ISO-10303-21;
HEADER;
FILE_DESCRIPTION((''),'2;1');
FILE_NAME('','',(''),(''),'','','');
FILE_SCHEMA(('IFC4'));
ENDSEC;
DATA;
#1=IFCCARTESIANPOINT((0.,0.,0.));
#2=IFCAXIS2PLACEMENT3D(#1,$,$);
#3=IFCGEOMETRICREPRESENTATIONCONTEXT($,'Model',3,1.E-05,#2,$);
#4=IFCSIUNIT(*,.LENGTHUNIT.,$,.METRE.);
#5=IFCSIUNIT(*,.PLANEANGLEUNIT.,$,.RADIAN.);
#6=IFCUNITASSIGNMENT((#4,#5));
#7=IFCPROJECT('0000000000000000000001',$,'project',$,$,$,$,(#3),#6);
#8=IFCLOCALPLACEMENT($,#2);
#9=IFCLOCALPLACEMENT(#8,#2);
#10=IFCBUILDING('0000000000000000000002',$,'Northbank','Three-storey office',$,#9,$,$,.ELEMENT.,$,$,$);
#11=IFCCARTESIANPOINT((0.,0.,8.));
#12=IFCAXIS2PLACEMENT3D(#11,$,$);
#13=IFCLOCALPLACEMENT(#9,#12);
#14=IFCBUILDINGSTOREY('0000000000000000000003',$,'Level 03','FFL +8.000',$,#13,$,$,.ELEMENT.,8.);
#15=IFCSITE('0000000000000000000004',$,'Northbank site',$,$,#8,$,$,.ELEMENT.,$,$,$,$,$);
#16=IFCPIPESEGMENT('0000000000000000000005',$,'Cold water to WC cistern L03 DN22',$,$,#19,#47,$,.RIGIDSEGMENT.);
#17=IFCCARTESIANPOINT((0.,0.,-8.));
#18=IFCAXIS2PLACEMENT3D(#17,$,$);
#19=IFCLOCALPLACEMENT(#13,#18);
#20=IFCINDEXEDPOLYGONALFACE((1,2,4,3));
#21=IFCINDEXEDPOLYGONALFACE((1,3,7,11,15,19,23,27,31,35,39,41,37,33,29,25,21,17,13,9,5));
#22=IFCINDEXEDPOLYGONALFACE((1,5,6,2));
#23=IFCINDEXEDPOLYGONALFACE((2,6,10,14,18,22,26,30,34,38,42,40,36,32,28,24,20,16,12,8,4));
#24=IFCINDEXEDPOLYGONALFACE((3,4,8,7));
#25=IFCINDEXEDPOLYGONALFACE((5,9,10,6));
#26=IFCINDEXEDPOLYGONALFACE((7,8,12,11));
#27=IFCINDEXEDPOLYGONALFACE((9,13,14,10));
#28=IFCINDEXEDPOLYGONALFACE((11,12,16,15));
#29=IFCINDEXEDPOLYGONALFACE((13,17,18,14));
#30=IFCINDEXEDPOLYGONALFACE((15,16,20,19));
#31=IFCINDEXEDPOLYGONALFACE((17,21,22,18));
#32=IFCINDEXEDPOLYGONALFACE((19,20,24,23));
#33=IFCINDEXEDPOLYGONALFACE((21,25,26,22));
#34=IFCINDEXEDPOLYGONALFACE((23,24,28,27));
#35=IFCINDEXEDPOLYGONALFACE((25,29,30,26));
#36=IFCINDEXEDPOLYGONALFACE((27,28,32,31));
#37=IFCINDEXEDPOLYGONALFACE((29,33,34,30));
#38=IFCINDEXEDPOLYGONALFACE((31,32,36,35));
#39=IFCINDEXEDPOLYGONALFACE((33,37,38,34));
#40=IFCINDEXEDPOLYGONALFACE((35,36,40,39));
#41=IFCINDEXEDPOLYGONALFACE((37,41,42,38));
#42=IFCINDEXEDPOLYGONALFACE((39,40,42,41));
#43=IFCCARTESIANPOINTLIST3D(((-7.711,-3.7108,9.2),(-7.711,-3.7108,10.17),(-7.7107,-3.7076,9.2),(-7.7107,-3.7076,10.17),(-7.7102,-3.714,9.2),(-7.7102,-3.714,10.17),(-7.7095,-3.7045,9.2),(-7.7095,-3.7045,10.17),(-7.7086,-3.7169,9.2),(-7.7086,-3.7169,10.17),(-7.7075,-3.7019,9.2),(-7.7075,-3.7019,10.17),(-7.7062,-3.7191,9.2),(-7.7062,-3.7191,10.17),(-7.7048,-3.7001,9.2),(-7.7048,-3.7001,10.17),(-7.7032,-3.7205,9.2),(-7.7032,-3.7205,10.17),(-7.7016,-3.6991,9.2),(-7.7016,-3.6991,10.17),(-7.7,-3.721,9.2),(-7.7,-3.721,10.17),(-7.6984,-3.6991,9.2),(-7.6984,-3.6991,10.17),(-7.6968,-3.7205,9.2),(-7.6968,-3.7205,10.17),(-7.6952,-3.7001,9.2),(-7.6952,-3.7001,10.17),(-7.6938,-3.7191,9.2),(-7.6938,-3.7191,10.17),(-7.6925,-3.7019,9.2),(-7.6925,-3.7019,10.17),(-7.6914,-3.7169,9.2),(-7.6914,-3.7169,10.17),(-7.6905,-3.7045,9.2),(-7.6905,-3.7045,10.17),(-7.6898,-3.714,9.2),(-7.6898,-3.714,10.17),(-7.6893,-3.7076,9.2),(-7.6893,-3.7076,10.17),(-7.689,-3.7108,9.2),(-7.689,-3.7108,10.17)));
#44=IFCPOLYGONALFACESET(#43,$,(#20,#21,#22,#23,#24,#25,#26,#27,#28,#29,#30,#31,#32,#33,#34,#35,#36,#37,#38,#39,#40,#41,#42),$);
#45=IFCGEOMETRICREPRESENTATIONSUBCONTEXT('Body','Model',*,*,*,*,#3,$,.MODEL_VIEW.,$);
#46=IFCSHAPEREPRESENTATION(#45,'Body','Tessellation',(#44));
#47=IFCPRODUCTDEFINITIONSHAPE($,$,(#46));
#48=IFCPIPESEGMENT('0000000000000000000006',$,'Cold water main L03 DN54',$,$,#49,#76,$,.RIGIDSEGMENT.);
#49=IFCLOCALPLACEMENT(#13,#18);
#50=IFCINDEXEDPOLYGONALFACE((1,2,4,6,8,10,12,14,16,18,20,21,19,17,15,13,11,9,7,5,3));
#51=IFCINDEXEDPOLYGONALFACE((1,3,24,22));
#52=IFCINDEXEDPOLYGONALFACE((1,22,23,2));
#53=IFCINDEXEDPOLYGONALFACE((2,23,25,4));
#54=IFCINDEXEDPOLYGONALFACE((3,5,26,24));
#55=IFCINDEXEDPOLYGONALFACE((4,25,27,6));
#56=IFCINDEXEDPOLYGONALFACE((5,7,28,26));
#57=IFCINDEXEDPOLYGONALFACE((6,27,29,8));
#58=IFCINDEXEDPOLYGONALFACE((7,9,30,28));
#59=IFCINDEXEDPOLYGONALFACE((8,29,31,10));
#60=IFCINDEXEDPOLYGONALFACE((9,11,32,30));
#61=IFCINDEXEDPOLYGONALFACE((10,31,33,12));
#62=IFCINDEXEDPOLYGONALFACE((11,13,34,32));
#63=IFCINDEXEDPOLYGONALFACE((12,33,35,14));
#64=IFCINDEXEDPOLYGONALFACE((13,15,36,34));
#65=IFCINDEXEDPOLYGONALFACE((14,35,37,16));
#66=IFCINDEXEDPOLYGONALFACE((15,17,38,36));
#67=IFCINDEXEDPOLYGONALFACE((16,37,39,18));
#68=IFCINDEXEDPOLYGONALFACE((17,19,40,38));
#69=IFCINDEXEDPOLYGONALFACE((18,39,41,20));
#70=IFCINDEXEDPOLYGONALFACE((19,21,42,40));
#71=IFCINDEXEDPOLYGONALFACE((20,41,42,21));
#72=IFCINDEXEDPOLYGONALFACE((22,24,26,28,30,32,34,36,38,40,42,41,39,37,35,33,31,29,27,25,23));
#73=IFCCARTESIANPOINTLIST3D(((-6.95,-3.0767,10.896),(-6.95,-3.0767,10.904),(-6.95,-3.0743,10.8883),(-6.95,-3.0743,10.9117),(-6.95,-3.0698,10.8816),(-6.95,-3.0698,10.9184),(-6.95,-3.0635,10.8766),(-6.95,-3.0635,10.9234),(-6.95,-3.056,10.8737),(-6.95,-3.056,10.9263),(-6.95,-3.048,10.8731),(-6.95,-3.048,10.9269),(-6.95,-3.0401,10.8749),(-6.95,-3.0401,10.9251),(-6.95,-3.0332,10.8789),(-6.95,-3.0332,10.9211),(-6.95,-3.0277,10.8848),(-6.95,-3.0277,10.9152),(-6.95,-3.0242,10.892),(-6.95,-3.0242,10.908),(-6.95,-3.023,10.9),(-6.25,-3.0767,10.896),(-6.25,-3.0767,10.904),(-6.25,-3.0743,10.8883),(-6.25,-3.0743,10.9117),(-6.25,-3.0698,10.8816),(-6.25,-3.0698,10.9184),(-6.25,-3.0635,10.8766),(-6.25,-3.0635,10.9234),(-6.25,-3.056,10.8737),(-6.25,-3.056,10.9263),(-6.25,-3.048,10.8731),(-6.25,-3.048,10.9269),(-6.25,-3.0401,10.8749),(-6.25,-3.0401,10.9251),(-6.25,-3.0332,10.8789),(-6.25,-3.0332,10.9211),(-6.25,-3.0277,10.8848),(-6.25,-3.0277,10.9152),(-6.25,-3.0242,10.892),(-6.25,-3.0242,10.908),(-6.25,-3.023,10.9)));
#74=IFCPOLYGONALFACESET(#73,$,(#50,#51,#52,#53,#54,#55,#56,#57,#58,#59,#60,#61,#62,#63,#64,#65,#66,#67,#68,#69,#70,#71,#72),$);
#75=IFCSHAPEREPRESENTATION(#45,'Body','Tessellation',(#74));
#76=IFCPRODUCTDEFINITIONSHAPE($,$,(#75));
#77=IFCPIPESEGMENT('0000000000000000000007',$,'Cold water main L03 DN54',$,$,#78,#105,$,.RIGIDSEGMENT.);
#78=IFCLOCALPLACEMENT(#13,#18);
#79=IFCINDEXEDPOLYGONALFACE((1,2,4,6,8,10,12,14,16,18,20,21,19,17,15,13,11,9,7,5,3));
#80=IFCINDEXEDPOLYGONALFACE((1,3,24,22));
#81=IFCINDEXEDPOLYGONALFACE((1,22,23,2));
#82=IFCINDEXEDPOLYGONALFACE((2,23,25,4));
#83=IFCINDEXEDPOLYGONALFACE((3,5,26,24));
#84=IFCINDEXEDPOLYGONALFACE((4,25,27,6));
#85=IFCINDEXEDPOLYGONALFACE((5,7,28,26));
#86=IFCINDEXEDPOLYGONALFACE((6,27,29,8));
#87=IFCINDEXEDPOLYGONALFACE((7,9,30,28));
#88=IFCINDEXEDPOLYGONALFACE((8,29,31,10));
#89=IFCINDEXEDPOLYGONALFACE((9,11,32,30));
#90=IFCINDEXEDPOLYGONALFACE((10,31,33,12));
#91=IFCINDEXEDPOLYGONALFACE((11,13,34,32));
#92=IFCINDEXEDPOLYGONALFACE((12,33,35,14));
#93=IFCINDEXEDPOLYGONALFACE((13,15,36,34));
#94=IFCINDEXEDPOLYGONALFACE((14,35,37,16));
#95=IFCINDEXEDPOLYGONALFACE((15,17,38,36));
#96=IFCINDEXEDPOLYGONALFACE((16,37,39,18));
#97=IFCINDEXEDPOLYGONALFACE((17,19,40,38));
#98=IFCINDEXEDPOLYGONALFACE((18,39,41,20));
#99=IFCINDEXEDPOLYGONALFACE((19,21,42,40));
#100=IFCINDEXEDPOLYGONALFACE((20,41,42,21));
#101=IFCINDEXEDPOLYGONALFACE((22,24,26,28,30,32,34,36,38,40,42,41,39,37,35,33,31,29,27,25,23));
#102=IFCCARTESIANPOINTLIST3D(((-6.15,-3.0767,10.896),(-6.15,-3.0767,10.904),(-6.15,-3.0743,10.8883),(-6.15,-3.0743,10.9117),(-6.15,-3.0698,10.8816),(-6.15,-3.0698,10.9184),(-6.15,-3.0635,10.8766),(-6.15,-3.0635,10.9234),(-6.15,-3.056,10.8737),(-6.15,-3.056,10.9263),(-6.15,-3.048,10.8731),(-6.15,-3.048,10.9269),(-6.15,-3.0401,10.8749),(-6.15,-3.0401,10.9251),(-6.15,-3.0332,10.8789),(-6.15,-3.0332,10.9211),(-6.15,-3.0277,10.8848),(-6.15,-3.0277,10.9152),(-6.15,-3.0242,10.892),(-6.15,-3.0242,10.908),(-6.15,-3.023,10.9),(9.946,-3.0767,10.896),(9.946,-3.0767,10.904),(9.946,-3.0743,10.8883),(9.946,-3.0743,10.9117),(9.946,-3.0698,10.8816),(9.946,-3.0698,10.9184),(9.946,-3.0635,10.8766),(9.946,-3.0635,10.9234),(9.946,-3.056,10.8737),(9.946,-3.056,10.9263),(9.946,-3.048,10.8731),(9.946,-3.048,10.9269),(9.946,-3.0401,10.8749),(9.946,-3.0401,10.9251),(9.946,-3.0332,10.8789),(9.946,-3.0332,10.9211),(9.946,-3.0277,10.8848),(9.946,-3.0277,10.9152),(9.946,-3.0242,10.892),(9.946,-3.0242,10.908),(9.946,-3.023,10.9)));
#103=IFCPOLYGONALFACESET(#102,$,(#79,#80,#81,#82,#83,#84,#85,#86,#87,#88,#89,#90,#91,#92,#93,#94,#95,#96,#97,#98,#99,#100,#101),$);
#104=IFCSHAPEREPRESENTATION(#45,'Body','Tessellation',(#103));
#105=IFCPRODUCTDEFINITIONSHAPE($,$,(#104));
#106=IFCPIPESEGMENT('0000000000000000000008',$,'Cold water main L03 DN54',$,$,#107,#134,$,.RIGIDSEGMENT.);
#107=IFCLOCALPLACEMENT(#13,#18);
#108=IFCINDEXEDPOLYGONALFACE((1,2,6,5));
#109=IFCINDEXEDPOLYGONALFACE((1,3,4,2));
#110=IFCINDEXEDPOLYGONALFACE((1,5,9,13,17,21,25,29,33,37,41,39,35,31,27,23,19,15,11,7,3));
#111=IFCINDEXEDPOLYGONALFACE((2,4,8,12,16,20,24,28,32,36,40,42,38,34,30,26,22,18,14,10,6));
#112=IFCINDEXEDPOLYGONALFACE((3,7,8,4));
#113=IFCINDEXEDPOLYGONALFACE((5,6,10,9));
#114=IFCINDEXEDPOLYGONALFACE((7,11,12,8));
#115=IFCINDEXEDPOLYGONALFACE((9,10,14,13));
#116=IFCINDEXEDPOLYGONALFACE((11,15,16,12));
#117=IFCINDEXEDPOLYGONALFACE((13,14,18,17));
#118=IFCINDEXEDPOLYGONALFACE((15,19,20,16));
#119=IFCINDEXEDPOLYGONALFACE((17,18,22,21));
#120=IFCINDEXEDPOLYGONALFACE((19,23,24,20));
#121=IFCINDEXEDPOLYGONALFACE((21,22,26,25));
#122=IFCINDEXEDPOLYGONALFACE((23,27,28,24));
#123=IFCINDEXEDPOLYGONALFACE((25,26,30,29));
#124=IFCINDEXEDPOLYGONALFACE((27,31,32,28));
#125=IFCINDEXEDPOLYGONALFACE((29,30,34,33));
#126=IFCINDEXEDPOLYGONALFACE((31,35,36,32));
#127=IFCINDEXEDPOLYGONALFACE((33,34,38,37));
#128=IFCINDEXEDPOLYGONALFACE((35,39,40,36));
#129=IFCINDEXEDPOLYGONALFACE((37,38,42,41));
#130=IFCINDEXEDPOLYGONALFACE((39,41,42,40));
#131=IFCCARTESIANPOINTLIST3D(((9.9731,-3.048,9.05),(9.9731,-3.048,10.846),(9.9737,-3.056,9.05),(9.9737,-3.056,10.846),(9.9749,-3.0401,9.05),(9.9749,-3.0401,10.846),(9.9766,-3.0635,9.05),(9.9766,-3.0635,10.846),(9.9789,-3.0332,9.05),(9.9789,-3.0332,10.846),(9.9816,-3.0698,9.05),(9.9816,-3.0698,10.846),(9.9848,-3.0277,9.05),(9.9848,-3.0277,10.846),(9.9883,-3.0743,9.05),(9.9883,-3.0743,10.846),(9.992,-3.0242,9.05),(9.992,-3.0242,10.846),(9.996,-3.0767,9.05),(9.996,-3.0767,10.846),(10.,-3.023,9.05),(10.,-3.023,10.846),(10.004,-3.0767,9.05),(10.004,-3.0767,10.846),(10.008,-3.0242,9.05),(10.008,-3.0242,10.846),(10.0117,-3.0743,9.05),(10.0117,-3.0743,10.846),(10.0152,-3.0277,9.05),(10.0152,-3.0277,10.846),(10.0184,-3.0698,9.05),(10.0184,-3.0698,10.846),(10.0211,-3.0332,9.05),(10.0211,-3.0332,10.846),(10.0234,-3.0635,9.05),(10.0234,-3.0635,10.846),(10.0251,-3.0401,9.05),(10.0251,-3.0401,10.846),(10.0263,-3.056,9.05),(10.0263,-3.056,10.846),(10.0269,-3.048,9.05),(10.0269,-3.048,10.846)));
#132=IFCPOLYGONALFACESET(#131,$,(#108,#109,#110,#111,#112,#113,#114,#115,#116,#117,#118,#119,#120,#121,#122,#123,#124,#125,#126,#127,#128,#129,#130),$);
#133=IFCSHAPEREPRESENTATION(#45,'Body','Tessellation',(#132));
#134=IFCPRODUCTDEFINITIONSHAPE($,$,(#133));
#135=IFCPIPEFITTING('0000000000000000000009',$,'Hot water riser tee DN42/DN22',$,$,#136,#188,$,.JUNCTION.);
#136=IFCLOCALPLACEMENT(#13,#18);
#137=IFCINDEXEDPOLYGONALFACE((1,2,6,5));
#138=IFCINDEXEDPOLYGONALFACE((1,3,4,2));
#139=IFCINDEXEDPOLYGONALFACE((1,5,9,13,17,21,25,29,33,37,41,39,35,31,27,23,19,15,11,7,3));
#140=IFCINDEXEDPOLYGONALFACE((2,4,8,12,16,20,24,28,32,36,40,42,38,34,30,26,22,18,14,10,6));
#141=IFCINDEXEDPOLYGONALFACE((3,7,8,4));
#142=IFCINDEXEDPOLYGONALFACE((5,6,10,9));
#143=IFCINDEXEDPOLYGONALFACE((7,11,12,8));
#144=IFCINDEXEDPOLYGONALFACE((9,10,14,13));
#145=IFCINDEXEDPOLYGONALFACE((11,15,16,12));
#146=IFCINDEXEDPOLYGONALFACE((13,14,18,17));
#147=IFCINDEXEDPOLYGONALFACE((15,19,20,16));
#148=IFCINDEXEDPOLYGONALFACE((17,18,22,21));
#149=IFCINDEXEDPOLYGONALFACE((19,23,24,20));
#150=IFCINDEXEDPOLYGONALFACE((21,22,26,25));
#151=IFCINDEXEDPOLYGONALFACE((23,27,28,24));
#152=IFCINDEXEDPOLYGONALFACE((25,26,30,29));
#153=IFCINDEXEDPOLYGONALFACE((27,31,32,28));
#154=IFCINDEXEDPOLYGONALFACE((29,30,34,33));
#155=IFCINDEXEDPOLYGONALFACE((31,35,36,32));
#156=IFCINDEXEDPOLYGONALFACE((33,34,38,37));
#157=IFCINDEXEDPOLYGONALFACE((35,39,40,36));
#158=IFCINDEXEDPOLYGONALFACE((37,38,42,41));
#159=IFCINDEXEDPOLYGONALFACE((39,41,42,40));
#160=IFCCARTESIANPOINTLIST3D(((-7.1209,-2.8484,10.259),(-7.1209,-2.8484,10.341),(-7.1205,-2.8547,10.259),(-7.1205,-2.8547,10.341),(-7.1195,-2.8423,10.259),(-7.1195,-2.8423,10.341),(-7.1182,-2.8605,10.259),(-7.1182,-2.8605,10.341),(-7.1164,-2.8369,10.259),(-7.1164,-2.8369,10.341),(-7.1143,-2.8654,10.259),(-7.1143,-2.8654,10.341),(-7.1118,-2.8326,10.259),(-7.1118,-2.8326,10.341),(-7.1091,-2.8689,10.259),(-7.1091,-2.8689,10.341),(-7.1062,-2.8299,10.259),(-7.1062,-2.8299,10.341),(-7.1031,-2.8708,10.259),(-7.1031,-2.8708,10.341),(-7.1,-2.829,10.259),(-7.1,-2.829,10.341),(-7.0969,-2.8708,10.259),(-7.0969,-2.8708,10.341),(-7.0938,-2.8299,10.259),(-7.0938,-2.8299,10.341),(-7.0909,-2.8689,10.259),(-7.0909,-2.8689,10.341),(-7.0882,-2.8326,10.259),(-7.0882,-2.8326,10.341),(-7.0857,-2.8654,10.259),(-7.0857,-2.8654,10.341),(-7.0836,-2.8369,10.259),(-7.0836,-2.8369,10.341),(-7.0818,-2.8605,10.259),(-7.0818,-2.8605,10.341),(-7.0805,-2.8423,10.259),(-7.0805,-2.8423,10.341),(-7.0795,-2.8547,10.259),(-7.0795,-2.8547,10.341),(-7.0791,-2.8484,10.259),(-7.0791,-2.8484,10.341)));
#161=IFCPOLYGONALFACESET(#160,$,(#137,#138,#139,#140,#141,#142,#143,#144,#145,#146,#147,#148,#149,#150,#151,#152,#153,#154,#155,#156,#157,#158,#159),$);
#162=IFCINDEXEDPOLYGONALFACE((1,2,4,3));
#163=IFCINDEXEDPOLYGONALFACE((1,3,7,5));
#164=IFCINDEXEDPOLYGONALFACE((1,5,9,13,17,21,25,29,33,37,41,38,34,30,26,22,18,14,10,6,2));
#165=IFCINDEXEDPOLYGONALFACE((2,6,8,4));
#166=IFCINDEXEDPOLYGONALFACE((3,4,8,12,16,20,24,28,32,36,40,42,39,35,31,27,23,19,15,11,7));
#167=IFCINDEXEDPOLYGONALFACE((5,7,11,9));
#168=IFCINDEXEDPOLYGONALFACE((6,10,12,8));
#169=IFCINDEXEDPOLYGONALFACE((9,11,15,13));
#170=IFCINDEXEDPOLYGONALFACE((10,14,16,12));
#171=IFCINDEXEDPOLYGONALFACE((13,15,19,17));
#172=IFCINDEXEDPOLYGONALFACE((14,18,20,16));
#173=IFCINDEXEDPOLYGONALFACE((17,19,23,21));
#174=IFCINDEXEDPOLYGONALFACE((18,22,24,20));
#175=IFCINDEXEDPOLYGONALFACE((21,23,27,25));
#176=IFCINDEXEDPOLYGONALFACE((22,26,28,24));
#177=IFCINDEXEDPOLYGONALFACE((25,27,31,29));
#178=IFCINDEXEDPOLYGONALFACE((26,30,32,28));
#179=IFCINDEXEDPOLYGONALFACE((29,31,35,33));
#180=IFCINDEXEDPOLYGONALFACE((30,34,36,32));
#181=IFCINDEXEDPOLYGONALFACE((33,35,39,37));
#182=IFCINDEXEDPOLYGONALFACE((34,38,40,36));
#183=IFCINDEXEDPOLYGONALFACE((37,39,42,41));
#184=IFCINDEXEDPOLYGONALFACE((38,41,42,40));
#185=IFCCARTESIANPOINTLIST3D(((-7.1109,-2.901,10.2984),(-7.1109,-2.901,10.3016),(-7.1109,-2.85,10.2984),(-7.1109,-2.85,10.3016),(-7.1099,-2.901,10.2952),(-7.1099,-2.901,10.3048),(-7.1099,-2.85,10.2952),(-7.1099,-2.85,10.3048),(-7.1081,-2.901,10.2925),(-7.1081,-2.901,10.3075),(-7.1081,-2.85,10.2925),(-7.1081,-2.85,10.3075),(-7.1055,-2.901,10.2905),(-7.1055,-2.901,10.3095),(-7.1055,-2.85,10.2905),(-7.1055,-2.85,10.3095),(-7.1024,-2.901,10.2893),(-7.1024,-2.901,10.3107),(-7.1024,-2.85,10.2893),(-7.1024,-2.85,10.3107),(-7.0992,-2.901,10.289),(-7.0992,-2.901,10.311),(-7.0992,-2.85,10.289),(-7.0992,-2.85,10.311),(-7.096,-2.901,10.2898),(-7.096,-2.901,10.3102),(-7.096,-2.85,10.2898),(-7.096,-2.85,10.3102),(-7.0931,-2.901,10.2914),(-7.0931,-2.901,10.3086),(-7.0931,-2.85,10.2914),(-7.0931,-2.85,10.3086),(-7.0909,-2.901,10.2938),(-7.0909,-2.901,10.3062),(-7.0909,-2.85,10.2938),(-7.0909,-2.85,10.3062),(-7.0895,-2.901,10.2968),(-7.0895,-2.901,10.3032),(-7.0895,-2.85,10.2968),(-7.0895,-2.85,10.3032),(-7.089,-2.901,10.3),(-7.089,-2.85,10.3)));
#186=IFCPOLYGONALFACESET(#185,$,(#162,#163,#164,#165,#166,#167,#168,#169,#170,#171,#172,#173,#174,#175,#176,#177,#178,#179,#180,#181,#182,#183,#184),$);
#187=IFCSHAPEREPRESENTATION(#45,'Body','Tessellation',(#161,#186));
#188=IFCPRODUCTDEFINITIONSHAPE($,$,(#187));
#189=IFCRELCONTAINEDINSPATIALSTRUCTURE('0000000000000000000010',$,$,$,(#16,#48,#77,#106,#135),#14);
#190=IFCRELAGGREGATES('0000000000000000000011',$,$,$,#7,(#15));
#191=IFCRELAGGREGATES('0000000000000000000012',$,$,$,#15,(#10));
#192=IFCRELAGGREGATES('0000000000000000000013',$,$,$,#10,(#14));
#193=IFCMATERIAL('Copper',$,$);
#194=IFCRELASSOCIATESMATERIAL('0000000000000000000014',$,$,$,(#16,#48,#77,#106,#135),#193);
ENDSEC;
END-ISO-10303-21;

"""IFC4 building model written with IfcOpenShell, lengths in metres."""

from ifc_helpers import new_model, si_unit, frame, origin, place, context, subcontext, project, spatial, circle, extrude, material, element, save


model = new_model("IFC4")

# Units and contexts
model_context = context("Model", 3, precision=1e-05, world=origin())
body_context = subcontext(model_context, "Body", "Model", "MODEL_VIEW")
ifc_project = project(units=[si_unit("LENGTHUNIT", "METRE"), si_unit("PLANEANGLEUNIT", "RADIAN")], contexts=[model_context])

# Site, building, storey
site_placement = place(None, origin())
site = spatial("IfcSite", under=ifc_project, at=site_placement, Name="Northbank site", CompositionType="ELEMENT")
building_placement = place(site_placement, origin())
building = spatial("IfcBuilding", under=site, at=building_placement, Name="Northbank", Description="Three-storey office", CompositionType="ELEMENT")
storey_placement = place(building_placement, frame((0.0, 0.0, 8.0)))
storey = spatial("IfcBuildingStorey", under=building, at=storey_placement, Name="Level 03", Description="FFL +8.000", CompositionType="ELEMENT", Elevation=8.0)

# Shared definitions
ifc_material_1 = material(Name="Copper")

# Pipe segments
pipe_segment_1_placement = place(storey_placement, frame((0.0, 0.0, -8.0)))
element("IfcPipeSegment", 1, at=pipe_segment_1_placement, inside=storey, material=ifc_material_1, Name="Cold water to WC cistern L03 DN22", PredefinedType="RIGIDSEGMENT", context=body_context, shape_type="SweptSolid", body=[
    extrude(circle(Radius=0.011), frame((-7.7, -3.71, 10.17), z_axis=(0.0, 0.0, -1.0), x_axis=(0.0, -1.0, 0.0)), (0.0, 0.0, 1.0), 0.97),
])
pipe_segment_2_placement = place(storey_placement, frame((0.0, 0.0, -8.0)))
element("IfcPipeSegment", 2, at=pipe_segment_2_placement, inside=storey, material=ifc_material_1, Name="Cold water main L03 DN54", PredefinedType="RIGIDSEGMENT", context=body_context, shape_type="SweptSolid", body=[
    extrude(circle(Radius=0.027), frame((-6.95, -3.05, 10.9), z_axis=(1.0, 0.0, 0.0), x_axis=(0.0, 1.0, 0.0)), (0.0, 0.0, 1.0), 0.7),
])

# Pipe segments
pipe_segment_3_placement = place(storey_placement, frame((0.0, 0.0, -8.0)))
element("IfcPipeSegment", 3, at=pipe_segment_3_placement, inside=storey, material=ifc_material_1, Name="Cold water main L03 DN54", PredefinedType="RIGIDSEGMENT", context=body_context, shape_type="SweptSolid", body=[
    extrude(circle(Radius=0.027), frame((-6.15, -3.05, 10.9), z_axis=(1.0, 0.0, 0.0), x_axis=(0.0, 1.0, 0.0)), (0.0, 0.0, 1.0), 16.096),
])
pipe_segment_4_placement = place(storey_placement, frame((0.0, 0.0, -8.0)))
element("IfcPipeSegment", 4, at=pipe_segment_4_placement, inside=storey, material=ifc_material_1, Name="Cold water main L03 DN54", PredefinedType="RIGIDSEGMENT", context=body_context, shape_type="SweptSolid", body=[
    extrude(circle(Radius=0.027), frame((10.0, -3.05, 10.846), z_axis=(0.0, 0.0, -1.0), x_axis=(0.0, 1.0, 0.0)), (0.0, 0.0, 1.0), 1.796),
])

# Pipe fitting
pipe_fitting_1_placement = place(storey_placement, frame((0.0, 0.0, -8.0)))
element("IfcPipeFitting", 5, at=pipe_fitting_1_placement, inside=storey, material=ifc_material_1, Name="Hot water riser tee DN42/DN22", PredefinedType="JUNCTION", context=body_context, shape_type="SweptSolid", body=[
    extrude(circle(Radius=0.021), frame((-7.1, -2.85, 10.259), z_axis=(0.0, 0.0, 1.0), x_axis=(0.0, 1.0, 0.0)), (0.0, 0.0, 1.0), 0.082),
    extrude(circle(Radius=0.011), frame((-7.1, -2.85, 10.3), z_axis=(0.0, -1.0, 0.0), x_axis=(1.0, 0.0, 0.0)), (0.0, 0.0, 1.0), 0.051),
])

save(model, "model.ifc")
